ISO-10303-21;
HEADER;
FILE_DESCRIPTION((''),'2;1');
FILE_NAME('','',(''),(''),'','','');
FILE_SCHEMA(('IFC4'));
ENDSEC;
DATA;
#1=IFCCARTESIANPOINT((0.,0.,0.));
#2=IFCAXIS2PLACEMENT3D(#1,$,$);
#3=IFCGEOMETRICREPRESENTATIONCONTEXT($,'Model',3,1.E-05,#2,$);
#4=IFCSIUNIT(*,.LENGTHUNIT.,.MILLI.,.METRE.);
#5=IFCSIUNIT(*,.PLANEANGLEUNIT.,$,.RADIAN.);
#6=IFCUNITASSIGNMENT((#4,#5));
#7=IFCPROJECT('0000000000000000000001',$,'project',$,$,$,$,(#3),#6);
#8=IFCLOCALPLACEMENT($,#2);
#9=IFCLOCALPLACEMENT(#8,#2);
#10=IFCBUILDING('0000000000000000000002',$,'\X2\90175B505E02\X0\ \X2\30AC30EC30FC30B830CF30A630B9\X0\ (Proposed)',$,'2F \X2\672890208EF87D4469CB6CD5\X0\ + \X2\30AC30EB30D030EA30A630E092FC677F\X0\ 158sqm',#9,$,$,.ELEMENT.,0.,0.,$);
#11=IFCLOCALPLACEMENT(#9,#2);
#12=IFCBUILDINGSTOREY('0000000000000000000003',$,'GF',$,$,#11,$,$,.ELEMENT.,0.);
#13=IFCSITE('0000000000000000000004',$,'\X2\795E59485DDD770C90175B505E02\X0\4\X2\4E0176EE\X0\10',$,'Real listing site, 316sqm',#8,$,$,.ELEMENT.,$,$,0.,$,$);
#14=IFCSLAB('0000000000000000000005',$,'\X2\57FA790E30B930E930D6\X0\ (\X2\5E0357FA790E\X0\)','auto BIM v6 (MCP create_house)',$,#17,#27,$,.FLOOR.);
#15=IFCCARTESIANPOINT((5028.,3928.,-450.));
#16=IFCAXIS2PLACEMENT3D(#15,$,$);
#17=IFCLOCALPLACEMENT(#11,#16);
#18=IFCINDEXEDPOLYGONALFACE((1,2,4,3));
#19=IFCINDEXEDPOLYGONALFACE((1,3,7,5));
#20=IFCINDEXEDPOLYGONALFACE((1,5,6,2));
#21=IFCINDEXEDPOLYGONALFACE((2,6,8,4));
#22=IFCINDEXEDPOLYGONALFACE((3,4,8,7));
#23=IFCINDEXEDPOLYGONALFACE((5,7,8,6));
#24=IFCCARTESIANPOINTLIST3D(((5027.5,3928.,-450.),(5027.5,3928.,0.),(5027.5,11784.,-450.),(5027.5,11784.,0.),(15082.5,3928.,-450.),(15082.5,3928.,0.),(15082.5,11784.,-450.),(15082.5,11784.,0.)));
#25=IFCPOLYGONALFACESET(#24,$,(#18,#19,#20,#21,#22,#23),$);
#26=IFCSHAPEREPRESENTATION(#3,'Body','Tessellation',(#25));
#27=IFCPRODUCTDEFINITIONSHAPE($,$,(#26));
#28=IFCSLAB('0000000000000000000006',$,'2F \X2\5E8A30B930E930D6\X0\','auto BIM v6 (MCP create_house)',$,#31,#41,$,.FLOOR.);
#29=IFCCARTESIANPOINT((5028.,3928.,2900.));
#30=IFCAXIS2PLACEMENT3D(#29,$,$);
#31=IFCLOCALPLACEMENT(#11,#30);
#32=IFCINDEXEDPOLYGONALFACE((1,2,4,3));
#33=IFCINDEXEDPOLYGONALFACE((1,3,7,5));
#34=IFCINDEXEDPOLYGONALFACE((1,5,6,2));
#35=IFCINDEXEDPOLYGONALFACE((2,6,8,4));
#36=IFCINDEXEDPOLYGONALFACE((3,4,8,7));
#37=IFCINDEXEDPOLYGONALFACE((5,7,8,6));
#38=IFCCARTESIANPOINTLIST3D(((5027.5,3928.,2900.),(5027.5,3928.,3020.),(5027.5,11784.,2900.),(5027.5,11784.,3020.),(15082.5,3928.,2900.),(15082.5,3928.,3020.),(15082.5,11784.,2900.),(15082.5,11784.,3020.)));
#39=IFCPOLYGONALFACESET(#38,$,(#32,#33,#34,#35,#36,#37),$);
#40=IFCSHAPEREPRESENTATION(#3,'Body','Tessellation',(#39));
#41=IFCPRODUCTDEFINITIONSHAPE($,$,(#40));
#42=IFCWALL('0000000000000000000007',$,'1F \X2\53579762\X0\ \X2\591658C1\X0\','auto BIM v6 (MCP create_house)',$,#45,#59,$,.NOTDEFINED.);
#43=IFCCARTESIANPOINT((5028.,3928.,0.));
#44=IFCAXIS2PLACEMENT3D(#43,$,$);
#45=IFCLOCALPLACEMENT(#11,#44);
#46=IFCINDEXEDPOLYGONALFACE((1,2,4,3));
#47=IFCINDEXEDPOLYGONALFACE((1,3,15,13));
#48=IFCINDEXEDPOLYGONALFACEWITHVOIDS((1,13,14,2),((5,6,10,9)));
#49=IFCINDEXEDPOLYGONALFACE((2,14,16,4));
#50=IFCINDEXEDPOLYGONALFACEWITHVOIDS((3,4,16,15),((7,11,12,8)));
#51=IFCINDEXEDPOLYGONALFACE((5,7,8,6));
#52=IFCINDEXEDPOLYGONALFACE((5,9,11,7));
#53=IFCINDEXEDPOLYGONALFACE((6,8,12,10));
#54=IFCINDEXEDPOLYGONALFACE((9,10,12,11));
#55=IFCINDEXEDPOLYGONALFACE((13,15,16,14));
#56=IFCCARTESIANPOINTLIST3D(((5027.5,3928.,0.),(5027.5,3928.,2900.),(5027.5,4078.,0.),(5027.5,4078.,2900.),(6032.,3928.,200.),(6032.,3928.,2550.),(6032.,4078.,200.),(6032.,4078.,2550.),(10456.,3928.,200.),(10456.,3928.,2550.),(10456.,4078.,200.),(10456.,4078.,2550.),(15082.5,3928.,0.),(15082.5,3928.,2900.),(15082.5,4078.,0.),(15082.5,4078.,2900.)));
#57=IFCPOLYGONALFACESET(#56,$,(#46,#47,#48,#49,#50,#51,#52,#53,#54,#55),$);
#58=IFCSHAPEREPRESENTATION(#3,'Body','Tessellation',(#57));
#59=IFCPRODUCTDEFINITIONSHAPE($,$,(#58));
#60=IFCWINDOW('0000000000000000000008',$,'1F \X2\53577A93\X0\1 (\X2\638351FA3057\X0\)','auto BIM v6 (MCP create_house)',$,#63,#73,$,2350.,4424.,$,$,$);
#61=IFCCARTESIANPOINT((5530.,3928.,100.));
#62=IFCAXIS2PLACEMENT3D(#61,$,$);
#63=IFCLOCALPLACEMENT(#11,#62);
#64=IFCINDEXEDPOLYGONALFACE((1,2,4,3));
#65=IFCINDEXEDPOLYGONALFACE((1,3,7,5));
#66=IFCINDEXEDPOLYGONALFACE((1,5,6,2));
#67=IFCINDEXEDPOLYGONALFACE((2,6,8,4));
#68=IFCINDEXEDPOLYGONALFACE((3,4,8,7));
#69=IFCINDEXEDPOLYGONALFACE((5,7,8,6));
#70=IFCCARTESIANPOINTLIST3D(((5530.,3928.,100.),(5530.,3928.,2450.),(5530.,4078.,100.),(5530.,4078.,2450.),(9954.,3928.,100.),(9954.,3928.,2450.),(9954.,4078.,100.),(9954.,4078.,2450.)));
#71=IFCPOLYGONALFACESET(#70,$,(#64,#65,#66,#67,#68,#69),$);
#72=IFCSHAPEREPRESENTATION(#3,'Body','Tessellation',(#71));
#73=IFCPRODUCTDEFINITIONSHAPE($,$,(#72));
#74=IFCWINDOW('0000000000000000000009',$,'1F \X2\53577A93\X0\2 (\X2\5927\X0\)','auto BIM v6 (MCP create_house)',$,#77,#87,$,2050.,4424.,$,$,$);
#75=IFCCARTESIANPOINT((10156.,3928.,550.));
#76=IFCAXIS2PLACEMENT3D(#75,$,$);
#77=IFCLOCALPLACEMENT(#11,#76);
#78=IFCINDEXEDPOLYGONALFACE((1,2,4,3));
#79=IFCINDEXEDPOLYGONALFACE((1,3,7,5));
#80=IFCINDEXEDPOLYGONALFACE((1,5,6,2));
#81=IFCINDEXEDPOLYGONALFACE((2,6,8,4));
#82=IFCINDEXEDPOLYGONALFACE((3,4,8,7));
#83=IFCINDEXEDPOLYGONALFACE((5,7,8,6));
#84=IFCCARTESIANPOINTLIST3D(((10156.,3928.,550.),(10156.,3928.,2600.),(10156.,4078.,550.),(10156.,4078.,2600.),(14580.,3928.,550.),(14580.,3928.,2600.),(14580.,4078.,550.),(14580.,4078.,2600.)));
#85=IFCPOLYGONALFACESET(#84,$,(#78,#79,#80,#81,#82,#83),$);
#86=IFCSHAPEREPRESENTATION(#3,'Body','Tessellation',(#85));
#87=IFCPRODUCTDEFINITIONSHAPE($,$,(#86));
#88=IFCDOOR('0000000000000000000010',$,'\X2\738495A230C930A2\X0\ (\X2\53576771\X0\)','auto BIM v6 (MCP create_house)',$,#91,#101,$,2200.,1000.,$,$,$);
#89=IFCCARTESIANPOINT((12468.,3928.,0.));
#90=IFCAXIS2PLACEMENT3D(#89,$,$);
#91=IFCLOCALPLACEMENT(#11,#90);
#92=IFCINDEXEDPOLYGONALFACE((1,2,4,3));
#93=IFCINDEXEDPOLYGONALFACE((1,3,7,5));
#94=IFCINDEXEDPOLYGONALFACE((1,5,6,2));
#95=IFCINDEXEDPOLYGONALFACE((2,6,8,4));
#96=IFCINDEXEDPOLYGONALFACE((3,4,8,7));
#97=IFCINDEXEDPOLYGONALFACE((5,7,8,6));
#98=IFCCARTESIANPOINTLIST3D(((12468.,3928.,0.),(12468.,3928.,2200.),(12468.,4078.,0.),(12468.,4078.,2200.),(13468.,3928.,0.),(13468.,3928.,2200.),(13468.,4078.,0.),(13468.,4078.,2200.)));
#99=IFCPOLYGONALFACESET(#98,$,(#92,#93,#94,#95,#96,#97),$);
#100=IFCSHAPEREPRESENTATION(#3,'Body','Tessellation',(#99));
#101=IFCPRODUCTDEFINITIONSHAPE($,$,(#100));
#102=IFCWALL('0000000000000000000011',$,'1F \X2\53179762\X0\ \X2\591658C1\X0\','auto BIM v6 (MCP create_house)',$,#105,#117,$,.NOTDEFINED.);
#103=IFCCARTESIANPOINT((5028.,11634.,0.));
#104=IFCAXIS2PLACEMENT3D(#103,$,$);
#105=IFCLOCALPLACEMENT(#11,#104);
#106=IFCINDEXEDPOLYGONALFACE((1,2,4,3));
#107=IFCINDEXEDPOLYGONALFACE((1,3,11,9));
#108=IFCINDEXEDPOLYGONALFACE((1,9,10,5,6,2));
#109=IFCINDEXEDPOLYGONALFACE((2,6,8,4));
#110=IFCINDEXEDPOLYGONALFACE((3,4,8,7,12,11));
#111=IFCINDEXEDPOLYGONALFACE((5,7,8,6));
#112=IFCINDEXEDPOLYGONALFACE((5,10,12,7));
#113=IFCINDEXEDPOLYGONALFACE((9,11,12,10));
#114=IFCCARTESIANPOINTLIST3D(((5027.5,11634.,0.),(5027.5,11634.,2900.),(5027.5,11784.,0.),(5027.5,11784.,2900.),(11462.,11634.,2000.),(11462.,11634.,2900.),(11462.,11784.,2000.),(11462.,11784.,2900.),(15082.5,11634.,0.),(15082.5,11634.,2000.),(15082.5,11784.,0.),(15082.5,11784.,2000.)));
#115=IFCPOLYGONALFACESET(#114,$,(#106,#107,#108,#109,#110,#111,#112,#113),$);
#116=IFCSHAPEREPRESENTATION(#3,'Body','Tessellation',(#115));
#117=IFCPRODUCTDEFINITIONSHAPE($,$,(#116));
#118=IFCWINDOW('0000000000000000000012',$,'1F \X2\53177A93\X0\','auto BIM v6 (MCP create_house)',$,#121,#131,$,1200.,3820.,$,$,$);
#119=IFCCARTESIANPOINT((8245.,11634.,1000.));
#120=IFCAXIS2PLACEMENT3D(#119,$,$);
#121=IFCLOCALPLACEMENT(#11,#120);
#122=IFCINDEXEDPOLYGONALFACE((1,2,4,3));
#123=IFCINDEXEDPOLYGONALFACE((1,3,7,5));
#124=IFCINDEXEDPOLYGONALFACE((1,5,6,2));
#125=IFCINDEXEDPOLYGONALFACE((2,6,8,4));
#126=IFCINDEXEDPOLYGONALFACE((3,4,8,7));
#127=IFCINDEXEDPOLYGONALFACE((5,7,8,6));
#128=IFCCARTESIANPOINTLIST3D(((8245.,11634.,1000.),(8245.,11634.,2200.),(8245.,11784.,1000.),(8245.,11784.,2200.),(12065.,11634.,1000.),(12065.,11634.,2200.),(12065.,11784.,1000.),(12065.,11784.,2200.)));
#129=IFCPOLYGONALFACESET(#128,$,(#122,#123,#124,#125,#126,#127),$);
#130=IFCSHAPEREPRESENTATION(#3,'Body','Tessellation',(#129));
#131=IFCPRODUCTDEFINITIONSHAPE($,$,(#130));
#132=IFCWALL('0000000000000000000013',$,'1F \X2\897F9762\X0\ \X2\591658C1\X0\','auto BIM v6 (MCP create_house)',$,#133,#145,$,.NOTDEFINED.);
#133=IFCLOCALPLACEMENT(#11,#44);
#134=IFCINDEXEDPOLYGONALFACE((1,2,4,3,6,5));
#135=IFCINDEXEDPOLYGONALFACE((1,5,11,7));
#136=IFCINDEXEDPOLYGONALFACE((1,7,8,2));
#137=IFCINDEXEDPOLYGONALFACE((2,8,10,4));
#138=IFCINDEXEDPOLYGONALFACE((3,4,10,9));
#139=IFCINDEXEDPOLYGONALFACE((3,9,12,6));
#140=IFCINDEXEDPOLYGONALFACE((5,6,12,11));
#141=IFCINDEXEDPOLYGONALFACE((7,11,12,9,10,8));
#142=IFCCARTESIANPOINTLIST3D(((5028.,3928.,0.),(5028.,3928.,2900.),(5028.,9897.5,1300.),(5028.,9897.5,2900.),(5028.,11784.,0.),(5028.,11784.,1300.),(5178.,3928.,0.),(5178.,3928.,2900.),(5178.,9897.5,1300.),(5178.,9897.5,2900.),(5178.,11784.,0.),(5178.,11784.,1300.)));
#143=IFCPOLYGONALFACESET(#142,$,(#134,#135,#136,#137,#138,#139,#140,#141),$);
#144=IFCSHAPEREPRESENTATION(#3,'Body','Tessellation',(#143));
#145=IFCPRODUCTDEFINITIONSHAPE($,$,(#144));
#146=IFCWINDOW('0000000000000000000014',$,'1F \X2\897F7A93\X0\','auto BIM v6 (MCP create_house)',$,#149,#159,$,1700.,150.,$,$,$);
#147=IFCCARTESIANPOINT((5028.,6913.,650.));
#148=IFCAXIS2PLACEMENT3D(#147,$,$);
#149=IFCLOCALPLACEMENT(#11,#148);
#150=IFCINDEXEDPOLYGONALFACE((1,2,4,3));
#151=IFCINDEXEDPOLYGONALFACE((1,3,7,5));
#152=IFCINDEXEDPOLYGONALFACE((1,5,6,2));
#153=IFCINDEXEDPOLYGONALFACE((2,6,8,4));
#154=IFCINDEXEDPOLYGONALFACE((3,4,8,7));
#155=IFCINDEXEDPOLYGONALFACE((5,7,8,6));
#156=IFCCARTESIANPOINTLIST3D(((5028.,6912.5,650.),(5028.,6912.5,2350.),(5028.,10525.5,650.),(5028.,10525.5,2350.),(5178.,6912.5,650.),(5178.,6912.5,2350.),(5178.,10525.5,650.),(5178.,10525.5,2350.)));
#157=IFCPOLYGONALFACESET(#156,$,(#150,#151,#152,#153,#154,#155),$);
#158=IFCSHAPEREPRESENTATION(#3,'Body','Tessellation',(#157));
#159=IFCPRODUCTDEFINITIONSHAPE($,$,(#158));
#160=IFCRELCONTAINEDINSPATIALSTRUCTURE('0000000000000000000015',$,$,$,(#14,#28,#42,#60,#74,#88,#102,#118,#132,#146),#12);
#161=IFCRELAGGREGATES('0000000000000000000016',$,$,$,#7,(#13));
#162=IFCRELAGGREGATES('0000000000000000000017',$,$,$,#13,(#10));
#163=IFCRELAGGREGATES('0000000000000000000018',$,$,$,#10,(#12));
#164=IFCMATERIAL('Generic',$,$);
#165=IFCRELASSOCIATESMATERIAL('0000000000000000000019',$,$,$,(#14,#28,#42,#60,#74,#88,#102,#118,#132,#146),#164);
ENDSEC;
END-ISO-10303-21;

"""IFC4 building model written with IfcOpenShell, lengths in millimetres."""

from ifc_helpers import new_model, si_unit, frame, frame_2d, origin, place, context, project, spatial, rectangle, extrude, material, element, fill, save


model = new_model("IFC4")

# Units and contexts
model_context = context("Model", 3, precision=1e-05, world=origin())
ifc_project = project(units=[si_unit("LENGTHUNIT", "METRE", prefix="MILLI"), si_unit("PLANEANGLEUNIT", "RADIAN")], contexts=[model_context])

# Site, building, storey
site_placement = place(None, origin())
site = spatial("IfcSite", under=ifc_project, at=site_placement, Name="神奈川県逗子市4丁目10", ObjectType="Real listing site, 316sqm", CompositionType="ELEMENT", RefElevation=0.0)
building_placement = place(site_placement, origin())
building = spatial("IfcBuilding", under=site, at=building_placement, Name="逗子市 ガレージハウス (Proposed)", ObjectType="2F 木造軸組構法 + ガルバリウム鋼板 158sqm", CompositionType="ELEMENT", ElevationOfRefHeight=0.0, ElevationOfTerrain=0.0)
storey_placement = place(building_placement, origin())
storey = spatial("IfcBuildingStorey", under=building, at=storey_placement, Name="GF", CompositionType="ELEMENT", Elevation=0.0)

# Slabs
ifc_material = material(Name="Generic")
slab_1_placement = place(storey_placement, frame((5028.0, 3928.0, -450.0)))
element("IfcSlab", 1, at=slab_1_placement, inside=storey, material=ifc_material, Name="基礎スラブ (布基礎)", Description="auto BIM v6 (MCP create_house)", PredefinedType="FLOOR", context=model_context, shape_type="SweptSolid", body=[
    extrude(rectangle(XDim=10055.0, YDim=7856.0, at=frame_2d((5027.0, 3928.0))), frame((5028.0, 3928.0, -450.0)), (0.0, 0.0, 1.0), 450.0),
])
slab_2_placement = place(storey_placement, frame((5028.0, 3928.0, 2900.0)))
element("IfcSlab", 2, at=slab_2_placement, inside=storey, material=ifc_material, Name="2F 床スラブ", Description="auto BIM v6 (MCP create_house)", PredefinedType="FLOOR", context=model_context, shape_type="SweptSolid", body=[
    extrude(rectangle(XDim=10055.0, YDim=7856.0, at=frame_2d((5027.0, 3928.0))), frame((5028.0, 3928.0, 2900.0)), (0.0, 0.0, 1.0), 120.0),
])

# Wall, openings, windows, door
wall_1_placement = place(storey_placement, frame((5028.0, 3928.0, 0.0)))
wall_1 = element("IfcWall", 3, at=wall_1_placement, inside=storey, material=ifc_material, Name="1F 南面 外壁", Description="auto BIM v6 (MCP create_house)", PredefinedType="NOTDEFINED", context=model_context, shape_type="SweptSolid", body=[
    extrude(rectangle(XDim=10055.0, YDim=150.0, at=frame_2d((5027.0, 75.0))), frame((5028.0, 3928.0, 0.0)), (0.0, 0.0, 1.0), 2900.0),
])
opening_1_placement = place(storey_placement, frame((5530.0, 3928.0, 100.0)))
opening_1 = element("IfcOpeningElement", 4, at=opening_1_placement, cuts=wall_1, PredefinedType="NOTDEFINED", context=model_context, shape_type="SweptSolid", body=[
    extrude(rectangle(XDim=4424.0, YDim=150.0, at=frame_2d((2212.0, 75.0))), frame((5530.0, 3928.0, 100.0)), (0.0, 0.0, 1.0), 2350.0),
])
opening_2_placement = place(storey_placement, frame((10156.0, 3928.0, 550.0)))
opening_2 = element("IfcOpeningElement", 5, at=opening_2_placement, cuts=wall_1, PredefinedType="NOTDEFINED", context=model_context, shape_type="SweptSolid", body=[
    extrude(rectangle(XDim=4424.0, YDim=150.0, at=frame_2d((2212.0, 75.0))), frame((10156.0, 3928.0, 550.0)), (0.0, 0.0, 1.0), 2050.0),
])
opening_3_placement = place(storey_placement, frame((12468.0, 3928.0, 0.0)))
opening_3 = element("IfcOpeningElement", 6, at=opening_3_placement, cuts=wall_1, PredefinedType="NOTDEFINED", context=model_context, shape_type="SweptSolid", body=[
    extrude(rectangle(XDim=1000.0, YDim=150.0, at=frame_2d((500.0, 75.0))), frame((12468.0, 3928.0, 0.0)), (0.0, 0.0, 1.0), 2200.0),
])
window_1_placement = place(storey_placement, frame((5530.0, 3928.0, 100.0)))
window_1 = element("IfcWindow", 7, at=window_1_placement, inside=storey, material=ifc_material, Name="1F 南窓1 (掃出し)", Description="auto BIM v6 (MCP create_house)", OverallHeight=2350.0, OverallWidth=4424.0, context=model_context, shape_type="SweptSolid", body=[
    extrude(rectangle(XDim=4424.0, YDim=150.0, at=frame_2d((2212.0, 75.0))), frame((5530.0, 3928.0, 100.0)), (0.0, 0.0, 1.0), 2350.0),
])
fill(opening_1, window_1)
window_2_placement = place(storey_placement, frame((10156.0, 3928.0, 550.0)))
window_2 = element("IfcWindow", 8, at=window_2_placement, inside=storey, material=ifc_material, Name="1F 南窓2 (大)", Description="auto BIM v6 (MCP create_house)", OverallHeight=2050.0, OverallWidth=4424.0, context=model_context, shape_type="SweptSolid", body=[
    extrude(rectangle(XDim=4424.0, YDim=150.0, at=frame_2d((2212.0, 75.0))), frame((10156.0, 3928.0, 550.0)), (0.0, 0.0, 1.0), 2050.0),
])
fill(opening_2, window_2)
door_placement = place(storey_placement, frame((12468.0, 3928.0, 0.0)))
door = element("IfcDoor", 9, at=door_placement, inside=storey, material=ifc_material, Name="玄関ドア (南東)", Description="auto BIM v6 (MCP create_house)", OverallHeight=2200.0, OverallWidth=1000.0, context=model_context, shape_type="SweptSolid", body=[
    extrude(rectangle(XDim=1000.0, YDim=150.0, at=frame_2d((500.0, 75.0))), frame((12468.0, 3928.0, 0.0)), (0.0, 0.0, 1.0), 2200.0),
])
fill(opening_3, door)

# Walls, openings, windows
wall_2_placement = place(storey_placement, frame((5028.0, 11634.0, 0.0)))
wall_2 = element("IfcWall", 10, at=wall_2_placement, inside=storey, material=ifc_material, Name="1F 北面 外壁", Description="auto BIM v6 (MCP create_house)", PredefinedType="NOTDEFINED", context=model_context, shape_type="SweptSolid", body=[
    extrude(rectangle(XDim=10055.0, YDim=150.0, at=frame_2d((5027.0, 75.0))), frame((5028.0, 11634.0, 0.0)), (0.0, 0.0, 1.0), 2900.0),
])
opening_4_placement = place(storey_placement, frame((8245.0, 11634.0, 1000.0)))
opening_4 = element("IfcOpeningElement", 11, at=opening_4_placement, cuts=wall_2, PredefinedType="NOTDEFINED", context=model_context, shape_type="SweptSolid", body=[
    extrude(rectangle(XDim=3820.0, YDim=150.0, at=frame_2d((1910.0, 75.0))), frame((8245.0, 11634.0, 1000.0)), (0.0, 0.0, 1.0), 1200.0),
])
window_3_placement = place(storey_placement, frame((8245.0, 11634.0, 1000.0)))
window_3 = element("IfcWindow", 12, at=window_3_placement, inside=storey, material=ifc_material, Name="1F 北窓", Description="auto BIM v6 (MCP create_house)", OverallHeight=1200.0, OverallWidth=3820.0, context=model_context, shape_type="SweptSolid", body=[
    extrude(rectangle(XDim=3820.0, YDim=150.0, at=frame_2d((1910.0, 75.0))), frame((8245.0, 11634.0, 1000.0)), (0.0, 0.0, 1.0), 1200.0),
])
fill(opening_4, window_3)
wall_3_placement = place(storey_placement, frame((5028.0, 3928.0, 0.0)))
wall_3 = element("IfcWall", 13, at=wall_3_placement, inside=storey, material=ifc_material, Name="1F 西面 外壁", Description="auto BIM v6 (MCP create_house)", PredefinedType="NOTDEFINED", context=model_context, shape_type="SweptSolid", body=[
    extrude(rectangle(XDim=150.0, YDim=7856.0, at=frame_2d((75.0, 3928.0))), frame((5028.0, 3928.0, 0.0)), (0.0, 0.0, 1.0), 2900.0),
])
opening_5_placement = place(storey_placement, frame((5028.0, 6913.0, 650.0)))
opening_5 = element("IfcOpeningElement", 14, at=opening_5_placement, cuts=wall_3, PredefinedType="NOTDEFINED", context=model_context, shape_type="SweptSolid", body=[
    extrude(rectangle(XDim=150.0, YDim=3613.0, at=frame_2d((75.0, 1806.0))), frame((5028.0, 6913.0, 650.0)), (0.0, 0.0, 1.0), 1700.0),
])
window_4_placement = place(storey_placement, frame((5028.0, 6913.0, 650.0)))
window_4 = element("IfcWindow", 15, at=window_4_placement, inside=storey, material=ifc_material, Name="1F 西窓", Description="auto BIM v6 (MCP create_house)", OverallHeight=1700.0, OverallWidth=150.0, context=model_context, shape_type="SweptSolid", body=[
    extrude(rectangle(XDim=150.0, YDim=3613.0, at=frame_2d((75.0, 1806.0))), frame((5028.0, 6913.0, 650.0)), (0.0, 0.0, 1.0), 1700.0),
])
fill(opening_5, window_4)

save(model, "model.ifc")
